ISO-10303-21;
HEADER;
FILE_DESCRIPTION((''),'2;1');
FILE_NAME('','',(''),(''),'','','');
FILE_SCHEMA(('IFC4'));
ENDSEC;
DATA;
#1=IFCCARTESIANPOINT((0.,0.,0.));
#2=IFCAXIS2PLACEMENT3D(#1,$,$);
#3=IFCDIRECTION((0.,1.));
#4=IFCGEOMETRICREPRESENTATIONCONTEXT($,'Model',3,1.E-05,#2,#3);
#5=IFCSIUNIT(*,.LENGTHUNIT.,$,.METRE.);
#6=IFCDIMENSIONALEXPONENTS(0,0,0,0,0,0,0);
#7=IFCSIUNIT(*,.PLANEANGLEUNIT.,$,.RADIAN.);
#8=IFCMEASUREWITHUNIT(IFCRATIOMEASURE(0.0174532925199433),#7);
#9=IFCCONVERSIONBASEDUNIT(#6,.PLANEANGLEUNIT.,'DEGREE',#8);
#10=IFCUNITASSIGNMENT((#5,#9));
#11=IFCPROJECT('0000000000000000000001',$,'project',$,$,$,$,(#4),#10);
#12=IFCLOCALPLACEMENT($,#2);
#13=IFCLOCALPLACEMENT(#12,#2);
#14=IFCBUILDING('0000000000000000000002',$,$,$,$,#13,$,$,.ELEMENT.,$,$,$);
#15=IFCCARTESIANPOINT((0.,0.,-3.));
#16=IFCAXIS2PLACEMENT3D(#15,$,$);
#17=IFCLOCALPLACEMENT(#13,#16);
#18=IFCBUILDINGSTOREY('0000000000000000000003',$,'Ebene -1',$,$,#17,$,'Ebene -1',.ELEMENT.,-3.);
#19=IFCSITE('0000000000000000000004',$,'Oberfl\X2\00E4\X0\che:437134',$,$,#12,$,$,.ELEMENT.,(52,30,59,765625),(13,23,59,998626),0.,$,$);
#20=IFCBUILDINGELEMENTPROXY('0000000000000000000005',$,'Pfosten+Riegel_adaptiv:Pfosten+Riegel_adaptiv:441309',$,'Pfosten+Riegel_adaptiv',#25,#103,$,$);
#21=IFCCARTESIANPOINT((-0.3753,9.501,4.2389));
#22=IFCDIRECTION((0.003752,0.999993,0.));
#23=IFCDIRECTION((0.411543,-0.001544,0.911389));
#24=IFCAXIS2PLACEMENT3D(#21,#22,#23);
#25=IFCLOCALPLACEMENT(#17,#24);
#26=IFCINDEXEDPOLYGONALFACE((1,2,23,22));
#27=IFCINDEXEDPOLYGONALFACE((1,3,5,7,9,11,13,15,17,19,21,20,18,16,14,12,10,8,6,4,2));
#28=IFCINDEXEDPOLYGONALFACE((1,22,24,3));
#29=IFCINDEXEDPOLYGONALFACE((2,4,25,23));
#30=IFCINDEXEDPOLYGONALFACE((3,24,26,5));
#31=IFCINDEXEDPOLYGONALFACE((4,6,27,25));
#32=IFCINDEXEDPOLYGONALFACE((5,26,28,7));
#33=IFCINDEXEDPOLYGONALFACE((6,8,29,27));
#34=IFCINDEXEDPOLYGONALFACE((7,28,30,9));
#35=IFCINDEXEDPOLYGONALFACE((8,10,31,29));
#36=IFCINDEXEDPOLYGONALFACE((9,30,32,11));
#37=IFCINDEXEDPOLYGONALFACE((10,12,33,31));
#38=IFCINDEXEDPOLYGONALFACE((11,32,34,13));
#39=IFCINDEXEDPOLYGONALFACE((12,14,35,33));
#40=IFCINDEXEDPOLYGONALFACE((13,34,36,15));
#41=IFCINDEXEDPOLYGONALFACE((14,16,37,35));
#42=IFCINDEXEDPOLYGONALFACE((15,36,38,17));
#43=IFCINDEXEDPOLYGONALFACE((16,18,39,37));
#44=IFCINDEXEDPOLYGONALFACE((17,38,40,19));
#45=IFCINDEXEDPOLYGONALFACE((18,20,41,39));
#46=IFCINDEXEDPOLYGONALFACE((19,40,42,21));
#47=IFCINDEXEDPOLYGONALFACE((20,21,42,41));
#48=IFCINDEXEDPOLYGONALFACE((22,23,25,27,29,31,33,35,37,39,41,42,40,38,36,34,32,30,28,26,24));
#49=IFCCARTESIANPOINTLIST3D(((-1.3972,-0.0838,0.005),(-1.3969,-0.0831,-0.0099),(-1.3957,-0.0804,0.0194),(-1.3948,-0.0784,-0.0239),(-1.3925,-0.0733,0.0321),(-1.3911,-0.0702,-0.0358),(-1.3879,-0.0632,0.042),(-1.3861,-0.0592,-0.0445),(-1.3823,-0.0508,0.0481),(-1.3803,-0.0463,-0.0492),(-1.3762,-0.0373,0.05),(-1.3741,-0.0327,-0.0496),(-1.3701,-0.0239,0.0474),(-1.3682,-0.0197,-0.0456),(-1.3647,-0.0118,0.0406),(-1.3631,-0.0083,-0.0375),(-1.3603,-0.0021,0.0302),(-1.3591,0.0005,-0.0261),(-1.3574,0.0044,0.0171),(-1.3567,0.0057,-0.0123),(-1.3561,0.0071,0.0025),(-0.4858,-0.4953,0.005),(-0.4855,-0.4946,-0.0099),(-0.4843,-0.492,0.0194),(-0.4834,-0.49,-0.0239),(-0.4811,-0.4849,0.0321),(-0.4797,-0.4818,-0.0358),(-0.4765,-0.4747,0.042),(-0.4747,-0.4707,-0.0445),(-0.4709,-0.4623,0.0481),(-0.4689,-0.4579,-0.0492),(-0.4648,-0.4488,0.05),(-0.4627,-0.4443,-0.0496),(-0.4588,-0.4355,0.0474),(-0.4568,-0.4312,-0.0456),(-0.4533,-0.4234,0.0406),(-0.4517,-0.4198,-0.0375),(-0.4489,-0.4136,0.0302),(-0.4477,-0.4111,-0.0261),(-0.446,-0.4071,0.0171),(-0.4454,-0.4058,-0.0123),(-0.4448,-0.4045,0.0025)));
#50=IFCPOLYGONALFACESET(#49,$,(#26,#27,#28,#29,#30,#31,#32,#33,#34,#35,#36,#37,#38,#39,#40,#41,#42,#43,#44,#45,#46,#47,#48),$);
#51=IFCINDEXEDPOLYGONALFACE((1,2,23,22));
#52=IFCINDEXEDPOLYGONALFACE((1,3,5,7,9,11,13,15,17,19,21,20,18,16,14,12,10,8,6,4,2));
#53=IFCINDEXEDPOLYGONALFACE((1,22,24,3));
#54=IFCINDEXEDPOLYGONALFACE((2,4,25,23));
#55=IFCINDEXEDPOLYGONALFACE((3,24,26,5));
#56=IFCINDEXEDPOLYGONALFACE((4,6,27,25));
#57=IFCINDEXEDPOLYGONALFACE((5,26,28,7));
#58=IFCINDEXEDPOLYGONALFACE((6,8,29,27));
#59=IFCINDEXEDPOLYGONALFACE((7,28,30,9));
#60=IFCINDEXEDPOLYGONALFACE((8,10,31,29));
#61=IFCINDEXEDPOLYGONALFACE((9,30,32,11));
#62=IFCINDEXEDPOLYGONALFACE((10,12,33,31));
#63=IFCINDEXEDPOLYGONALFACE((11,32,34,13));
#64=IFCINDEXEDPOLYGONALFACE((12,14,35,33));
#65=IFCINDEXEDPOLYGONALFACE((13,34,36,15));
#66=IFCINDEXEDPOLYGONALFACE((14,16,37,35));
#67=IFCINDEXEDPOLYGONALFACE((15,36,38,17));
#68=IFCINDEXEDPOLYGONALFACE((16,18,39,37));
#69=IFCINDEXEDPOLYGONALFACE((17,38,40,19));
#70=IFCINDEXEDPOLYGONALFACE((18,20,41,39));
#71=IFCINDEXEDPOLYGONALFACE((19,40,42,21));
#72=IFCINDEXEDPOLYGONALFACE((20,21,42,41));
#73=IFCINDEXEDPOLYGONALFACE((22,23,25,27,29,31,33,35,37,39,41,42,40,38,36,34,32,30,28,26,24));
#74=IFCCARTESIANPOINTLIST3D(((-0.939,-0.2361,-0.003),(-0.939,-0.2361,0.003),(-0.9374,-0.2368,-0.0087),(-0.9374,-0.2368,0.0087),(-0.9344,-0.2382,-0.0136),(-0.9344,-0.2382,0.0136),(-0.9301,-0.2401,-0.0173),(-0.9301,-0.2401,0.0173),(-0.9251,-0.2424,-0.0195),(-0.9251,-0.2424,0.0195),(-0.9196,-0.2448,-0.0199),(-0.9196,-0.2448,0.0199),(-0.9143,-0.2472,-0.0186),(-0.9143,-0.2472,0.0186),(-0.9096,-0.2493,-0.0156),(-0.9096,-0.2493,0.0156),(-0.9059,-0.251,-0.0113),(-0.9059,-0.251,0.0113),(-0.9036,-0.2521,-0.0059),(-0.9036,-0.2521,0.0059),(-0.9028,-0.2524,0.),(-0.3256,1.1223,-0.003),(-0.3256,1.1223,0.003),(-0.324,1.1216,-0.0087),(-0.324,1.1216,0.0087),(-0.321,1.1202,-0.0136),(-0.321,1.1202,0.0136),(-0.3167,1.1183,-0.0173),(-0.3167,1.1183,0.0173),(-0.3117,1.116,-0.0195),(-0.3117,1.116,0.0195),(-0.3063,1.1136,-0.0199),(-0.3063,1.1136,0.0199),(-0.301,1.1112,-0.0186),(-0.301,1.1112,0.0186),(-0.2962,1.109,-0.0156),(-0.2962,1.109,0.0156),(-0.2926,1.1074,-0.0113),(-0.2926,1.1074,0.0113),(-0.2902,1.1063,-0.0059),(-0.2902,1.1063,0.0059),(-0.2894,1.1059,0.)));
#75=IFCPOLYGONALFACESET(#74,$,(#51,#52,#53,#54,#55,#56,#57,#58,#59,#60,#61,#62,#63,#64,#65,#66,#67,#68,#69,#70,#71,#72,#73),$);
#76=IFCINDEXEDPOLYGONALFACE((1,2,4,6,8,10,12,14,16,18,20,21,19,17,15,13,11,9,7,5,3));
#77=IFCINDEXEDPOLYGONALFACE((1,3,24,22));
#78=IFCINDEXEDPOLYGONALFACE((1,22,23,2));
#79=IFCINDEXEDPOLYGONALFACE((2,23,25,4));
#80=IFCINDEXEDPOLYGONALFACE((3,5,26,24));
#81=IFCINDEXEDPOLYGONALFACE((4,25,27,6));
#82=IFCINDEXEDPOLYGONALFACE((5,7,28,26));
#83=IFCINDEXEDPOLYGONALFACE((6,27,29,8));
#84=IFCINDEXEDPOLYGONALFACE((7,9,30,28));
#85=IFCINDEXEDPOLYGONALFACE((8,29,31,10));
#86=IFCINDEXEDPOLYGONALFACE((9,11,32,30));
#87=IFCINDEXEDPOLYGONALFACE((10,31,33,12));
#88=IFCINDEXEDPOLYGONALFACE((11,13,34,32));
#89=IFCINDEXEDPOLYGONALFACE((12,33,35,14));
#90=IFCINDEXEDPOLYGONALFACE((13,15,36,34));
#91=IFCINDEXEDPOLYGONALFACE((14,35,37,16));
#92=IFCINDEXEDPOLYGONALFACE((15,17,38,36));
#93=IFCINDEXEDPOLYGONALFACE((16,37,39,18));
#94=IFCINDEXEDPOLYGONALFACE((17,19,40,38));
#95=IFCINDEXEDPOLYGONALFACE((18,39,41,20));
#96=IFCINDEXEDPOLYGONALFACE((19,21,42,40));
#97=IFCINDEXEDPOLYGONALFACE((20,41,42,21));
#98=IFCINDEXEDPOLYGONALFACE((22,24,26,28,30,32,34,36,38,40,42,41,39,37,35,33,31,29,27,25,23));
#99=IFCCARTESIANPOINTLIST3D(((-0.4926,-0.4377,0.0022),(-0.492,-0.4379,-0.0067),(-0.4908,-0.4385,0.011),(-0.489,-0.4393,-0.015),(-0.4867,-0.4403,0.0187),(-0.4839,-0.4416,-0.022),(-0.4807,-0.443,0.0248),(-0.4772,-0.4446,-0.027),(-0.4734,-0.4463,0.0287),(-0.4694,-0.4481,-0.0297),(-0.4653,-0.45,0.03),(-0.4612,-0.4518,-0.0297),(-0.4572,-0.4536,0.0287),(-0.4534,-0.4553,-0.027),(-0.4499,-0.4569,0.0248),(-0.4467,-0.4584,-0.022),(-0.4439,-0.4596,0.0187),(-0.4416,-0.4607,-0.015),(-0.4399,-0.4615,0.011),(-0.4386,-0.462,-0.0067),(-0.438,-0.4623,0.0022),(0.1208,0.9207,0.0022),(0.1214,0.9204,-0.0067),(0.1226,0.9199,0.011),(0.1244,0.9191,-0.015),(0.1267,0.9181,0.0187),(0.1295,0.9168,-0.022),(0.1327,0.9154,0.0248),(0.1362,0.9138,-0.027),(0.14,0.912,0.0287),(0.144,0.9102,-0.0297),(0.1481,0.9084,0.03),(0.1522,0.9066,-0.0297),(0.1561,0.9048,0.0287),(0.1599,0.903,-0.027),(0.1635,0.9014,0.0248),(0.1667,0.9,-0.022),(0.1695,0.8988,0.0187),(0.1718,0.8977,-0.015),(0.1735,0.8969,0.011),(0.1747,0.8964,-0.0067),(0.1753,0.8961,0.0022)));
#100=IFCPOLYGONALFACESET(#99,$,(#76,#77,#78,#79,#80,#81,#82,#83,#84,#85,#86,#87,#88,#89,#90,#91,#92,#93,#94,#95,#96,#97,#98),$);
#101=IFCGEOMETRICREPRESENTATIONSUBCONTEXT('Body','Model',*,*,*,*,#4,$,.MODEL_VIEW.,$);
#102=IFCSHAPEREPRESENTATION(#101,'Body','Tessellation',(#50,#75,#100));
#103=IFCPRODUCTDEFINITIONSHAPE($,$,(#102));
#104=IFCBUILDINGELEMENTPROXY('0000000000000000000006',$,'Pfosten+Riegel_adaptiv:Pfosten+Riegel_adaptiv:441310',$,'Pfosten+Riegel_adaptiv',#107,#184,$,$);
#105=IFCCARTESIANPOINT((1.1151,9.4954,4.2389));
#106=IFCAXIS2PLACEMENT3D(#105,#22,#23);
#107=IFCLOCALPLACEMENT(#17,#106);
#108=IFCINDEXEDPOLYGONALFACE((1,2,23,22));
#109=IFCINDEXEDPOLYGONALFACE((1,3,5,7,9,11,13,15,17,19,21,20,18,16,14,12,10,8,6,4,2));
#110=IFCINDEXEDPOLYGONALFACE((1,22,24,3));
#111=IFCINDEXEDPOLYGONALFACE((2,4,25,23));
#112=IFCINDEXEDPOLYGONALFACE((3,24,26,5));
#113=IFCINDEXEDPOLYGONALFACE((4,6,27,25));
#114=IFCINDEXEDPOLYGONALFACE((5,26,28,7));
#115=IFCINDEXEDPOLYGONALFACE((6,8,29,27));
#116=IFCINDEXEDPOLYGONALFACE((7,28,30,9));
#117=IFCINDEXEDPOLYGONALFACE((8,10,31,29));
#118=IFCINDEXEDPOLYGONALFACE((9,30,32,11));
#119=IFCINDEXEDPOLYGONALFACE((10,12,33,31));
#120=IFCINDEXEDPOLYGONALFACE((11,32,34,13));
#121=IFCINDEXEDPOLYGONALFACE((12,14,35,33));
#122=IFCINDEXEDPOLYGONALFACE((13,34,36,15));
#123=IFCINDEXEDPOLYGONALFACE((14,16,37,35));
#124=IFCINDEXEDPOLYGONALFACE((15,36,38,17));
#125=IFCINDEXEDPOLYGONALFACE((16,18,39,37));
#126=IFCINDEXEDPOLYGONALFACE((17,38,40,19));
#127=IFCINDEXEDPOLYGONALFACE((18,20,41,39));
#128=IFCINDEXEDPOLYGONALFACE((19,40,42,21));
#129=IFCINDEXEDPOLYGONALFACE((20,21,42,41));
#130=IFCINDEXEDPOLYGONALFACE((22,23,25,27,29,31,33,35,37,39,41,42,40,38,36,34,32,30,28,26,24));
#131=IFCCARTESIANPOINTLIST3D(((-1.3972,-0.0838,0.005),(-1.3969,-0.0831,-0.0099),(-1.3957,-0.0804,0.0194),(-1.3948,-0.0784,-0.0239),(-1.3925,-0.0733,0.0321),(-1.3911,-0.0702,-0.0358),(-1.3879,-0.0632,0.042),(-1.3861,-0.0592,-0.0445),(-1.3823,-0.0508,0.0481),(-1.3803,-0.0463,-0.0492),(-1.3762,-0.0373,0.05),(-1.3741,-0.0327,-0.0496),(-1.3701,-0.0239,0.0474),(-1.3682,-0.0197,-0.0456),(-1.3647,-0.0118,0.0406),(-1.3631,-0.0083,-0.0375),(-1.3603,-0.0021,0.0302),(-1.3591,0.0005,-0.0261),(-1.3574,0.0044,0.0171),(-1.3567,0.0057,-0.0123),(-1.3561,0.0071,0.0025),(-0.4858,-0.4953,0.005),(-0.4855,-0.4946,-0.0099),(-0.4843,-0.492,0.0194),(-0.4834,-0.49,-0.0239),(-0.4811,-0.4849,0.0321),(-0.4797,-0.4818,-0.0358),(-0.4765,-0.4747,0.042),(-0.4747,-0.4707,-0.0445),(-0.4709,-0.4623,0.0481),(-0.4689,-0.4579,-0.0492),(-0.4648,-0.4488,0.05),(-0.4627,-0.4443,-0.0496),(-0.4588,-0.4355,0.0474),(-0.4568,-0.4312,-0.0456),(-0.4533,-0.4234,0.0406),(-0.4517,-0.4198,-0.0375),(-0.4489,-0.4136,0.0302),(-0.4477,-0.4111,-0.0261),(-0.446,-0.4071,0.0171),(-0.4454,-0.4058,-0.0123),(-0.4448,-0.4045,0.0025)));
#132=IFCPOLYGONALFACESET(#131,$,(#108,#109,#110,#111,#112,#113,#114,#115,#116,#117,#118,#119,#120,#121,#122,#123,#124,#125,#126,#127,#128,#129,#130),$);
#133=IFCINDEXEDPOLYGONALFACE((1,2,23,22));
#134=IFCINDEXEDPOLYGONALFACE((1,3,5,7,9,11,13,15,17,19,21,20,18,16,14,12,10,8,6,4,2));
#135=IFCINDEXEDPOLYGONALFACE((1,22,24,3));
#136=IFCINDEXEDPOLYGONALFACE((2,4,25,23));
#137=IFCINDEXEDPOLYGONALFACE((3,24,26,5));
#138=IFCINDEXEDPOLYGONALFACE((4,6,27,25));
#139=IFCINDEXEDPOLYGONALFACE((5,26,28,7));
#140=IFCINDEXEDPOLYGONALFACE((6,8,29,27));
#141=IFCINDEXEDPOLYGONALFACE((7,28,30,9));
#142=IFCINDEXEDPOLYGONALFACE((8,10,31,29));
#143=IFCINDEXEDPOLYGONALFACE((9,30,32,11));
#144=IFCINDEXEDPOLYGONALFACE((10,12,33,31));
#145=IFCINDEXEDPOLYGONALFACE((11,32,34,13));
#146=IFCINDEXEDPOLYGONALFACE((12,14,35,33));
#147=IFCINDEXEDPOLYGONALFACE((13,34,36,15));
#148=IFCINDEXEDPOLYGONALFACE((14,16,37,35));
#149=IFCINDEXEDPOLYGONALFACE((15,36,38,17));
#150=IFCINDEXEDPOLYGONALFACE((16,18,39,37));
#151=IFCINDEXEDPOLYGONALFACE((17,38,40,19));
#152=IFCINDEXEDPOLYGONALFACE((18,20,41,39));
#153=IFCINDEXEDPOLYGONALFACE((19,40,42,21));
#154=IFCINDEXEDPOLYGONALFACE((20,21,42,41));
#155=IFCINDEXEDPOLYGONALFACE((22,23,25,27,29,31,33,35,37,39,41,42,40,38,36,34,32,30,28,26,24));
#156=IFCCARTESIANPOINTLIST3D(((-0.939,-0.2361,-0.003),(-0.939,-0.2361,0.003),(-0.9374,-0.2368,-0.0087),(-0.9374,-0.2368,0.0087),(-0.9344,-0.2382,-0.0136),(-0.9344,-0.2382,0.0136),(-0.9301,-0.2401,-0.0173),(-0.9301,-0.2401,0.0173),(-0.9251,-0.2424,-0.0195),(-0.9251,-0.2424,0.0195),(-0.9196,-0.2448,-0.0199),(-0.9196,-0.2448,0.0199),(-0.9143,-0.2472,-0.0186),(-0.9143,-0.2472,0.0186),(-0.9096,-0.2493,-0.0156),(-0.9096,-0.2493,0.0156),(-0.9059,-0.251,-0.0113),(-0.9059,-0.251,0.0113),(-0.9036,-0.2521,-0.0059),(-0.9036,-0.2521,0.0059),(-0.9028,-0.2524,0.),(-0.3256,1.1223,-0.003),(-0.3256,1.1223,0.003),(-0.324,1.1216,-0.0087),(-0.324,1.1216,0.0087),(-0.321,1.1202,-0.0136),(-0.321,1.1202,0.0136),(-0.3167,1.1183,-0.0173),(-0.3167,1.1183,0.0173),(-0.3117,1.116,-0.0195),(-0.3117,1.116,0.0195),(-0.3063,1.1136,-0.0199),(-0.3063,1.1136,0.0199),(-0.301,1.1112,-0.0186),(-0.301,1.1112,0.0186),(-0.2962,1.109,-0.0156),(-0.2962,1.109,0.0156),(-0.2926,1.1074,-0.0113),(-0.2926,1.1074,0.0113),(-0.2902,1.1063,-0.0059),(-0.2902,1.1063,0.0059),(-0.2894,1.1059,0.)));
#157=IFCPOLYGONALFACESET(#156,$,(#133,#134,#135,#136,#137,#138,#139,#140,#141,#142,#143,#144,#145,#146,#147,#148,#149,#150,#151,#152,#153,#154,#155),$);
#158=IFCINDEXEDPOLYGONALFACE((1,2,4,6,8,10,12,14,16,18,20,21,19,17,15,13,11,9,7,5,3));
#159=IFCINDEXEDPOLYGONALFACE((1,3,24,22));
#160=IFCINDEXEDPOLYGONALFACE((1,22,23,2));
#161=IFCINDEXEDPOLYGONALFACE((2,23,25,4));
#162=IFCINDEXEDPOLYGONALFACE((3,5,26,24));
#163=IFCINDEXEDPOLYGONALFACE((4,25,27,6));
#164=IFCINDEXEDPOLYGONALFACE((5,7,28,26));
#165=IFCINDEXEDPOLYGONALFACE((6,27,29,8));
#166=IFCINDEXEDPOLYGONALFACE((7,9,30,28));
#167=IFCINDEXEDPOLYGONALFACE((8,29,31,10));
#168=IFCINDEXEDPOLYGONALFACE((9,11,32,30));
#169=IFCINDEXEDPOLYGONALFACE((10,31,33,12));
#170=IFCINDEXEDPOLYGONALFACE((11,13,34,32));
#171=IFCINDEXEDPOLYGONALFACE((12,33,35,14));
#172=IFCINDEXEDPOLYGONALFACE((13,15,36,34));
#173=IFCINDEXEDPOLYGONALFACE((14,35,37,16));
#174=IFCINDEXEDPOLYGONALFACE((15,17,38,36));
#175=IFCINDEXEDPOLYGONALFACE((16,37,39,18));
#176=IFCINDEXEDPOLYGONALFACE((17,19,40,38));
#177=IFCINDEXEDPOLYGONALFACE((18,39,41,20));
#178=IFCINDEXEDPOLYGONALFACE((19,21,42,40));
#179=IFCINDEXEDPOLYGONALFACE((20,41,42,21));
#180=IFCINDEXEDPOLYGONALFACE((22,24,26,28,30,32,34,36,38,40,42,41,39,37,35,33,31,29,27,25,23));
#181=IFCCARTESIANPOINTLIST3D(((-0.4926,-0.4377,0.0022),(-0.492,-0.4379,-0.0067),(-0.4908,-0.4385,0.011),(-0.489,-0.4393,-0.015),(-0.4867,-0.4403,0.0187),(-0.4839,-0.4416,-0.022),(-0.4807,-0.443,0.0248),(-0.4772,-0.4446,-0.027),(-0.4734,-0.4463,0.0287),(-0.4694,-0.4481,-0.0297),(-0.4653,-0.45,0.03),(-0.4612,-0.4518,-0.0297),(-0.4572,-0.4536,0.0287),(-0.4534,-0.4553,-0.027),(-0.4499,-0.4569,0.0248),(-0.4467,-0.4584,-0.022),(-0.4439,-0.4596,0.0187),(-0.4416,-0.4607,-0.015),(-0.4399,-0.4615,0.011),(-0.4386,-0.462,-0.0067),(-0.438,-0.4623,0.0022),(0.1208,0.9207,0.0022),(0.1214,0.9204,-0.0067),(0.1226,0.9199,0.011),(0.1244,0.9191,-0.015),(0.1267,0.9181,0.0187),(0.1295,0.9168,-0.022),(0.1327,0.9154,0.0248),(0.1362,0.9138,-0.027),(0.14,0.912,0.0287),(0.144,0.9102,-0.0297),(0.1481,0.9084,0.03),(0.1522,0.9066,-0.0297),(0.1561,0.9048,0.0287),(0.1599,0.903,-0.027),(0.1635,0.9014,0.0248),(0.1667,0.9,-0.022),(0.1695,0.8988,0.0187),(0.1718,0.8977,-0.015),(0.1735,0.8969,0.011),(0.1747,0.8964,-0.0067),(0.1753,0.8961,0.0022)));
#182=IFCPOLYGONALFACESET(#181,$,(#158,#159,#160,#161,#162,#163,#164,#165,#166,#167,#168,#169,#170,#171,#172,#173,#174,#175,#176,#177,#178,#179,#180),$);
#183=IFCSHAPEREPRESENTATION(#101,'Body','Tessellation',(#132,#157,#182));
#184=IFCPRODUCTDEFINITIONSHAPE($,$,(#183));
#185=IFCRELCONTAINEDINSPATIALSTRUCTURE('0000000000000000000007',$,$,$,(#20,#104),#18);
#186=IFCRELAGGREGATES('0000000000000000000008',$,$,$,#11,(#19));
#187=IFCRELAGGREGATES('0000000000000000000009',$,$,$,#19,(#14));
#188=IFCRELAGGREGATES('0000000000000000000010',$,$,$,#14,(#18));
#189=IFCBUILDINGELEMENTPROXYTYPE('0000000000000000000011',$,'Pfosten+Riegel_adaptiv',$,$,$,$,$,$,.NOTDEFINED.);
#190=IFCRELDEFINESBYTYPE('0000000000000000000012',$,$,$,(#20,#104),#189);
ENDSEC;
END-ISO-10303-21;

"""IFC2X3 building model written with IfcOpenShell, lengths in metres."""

from ifc_helpers import new_model, entity, si_unit, converted_unit, direction, frame, frame_2d, origin, place, context, subcontext, project, spatial, circle, extrude, source, transform, mapped, type_object, type_shapes, element, save


model = new_model("IFC2X3")

# Units and contexts
model_context = context("Model", 3, precision=1e-05, world=origin(), true_north=direction((0.0, 1.0)))
body_context = subcontext(model_context, "Body", "Model", "MODEL_VIEW")
ifc_project = project(units=[si_unit("LENGTHUNIT", "METRE"), converted_unit("PLANEANGLEUNIT", "DEGREE", entity("IfcRatioMeasure", 0.0174532925199433), si_unit("PLANEANGLEUNIT", "RADIAN"), dimensions=[0, 0, 0, 0, 0, 0, 0])], contexts=[model_context])

# Site, building, storey
site_placement = place(None, origin())
site = spatial("IfcSite", under=ifc_project, at=site_placement, Name="Oberfläche:437134", CompositionType="ELEMENT", RefLatitude=(52, 30, 59, 765625), RefLongitude=(13, 23, 59, 998626), RefElevation=0.0)
building_placement = place(site_placement, origin())
building = spatial("IfcBuilding", under=site, at=building_placement, CompositionType="ELEMENT")
storey_placement = place(building_placement, frame((0.0, 0.0, -3.0)))
storey = spatial("IfcBuildingStorey", under=building, at=storey_placement, Name="Ebene -1", LongName="Ebene -1", CompositionType="ELEMENT", Elevation=-3.0)

# Building element proxies
building_element_proxy_type_1 = type_object("IfcBuildingElementProxyType", Name="Pfosten+Riegel_adaptiv", PredefinedType="NOTDEFINED")
shared_shape_1 = source(origin(), body_context, "Body", "SweptSolid", [
    extrude(circle(Radius=0.05, at=frame_2d((0.0, 0.0), x_axis=(1.0, 0.0))), frame((-0.4653, -0.45, 0.0), z_axis=(-0.911389, 0.411546, 0.0), x_axis=(0.16937, 0.375078, -0.911389)), (0.0, 0.0, 1.0), 1.0),
    extrude(circle(Radius=0.02, at=frame_2d((0.0, 0.0), x_axis=(1.0, 0.0))), frame((-0.921, -0.2442, 0.0), z_axis=(0.411546, 0.911389, 0.0), x_axis=(0.911389, -0.411546, 0.0)), (0.0, 0.0, 1.0), 1.4904),
    extrude(circle(Radius=0.03, at=frame_2d((0.0, 0.0), x_axis=(1.0, 0.0))), frame((-0.4653, -0.45, 0.0), z_axis=(0.411546, 0.911389, 0.0), x_axis=(0.0, 0.0, 1.0)), (0.0, 0.0, 1.0), 1.4904),
])
type_shapes(building_element_proxy_type_1, [shared_shape_1])
for number, where, z_axis, x_axis, name in (
    (1, (-0.3753, 9.501, 4.2389), (0.003752, 0.999993, 0.0), (0.411543, -0.001544, 0.911389), "Pfosten+Riegel_adaptiv:Pfosten+Riegel_adaptiv:441309"),
    (2, (1.1151, 9.4954, 4.2389), (0.003752, 0.999993, 0.0), (0.411543, -0.001544, 0.911389), "Pfosten+Riegel_adaptiv:Pfosten+Riegel_adaptiv:441310"),
):
    element("IfcBuildingElementProxy", number, at=place(storey_placement, frame(where, z_axis=z_axis, x_axis=x_axis)), inside=storey, type_object=building_element_proxy_type_1, Name=name, ObjectType="Pfosten+Riegel_adaptiv", context=body_context, shape_type="MappedRepresentation", body=[
        mapped(shared_shape_1, transform((0.0, 0.0, 0.0), scale=1.0)),
    ])

save(model, "model.ifc")
